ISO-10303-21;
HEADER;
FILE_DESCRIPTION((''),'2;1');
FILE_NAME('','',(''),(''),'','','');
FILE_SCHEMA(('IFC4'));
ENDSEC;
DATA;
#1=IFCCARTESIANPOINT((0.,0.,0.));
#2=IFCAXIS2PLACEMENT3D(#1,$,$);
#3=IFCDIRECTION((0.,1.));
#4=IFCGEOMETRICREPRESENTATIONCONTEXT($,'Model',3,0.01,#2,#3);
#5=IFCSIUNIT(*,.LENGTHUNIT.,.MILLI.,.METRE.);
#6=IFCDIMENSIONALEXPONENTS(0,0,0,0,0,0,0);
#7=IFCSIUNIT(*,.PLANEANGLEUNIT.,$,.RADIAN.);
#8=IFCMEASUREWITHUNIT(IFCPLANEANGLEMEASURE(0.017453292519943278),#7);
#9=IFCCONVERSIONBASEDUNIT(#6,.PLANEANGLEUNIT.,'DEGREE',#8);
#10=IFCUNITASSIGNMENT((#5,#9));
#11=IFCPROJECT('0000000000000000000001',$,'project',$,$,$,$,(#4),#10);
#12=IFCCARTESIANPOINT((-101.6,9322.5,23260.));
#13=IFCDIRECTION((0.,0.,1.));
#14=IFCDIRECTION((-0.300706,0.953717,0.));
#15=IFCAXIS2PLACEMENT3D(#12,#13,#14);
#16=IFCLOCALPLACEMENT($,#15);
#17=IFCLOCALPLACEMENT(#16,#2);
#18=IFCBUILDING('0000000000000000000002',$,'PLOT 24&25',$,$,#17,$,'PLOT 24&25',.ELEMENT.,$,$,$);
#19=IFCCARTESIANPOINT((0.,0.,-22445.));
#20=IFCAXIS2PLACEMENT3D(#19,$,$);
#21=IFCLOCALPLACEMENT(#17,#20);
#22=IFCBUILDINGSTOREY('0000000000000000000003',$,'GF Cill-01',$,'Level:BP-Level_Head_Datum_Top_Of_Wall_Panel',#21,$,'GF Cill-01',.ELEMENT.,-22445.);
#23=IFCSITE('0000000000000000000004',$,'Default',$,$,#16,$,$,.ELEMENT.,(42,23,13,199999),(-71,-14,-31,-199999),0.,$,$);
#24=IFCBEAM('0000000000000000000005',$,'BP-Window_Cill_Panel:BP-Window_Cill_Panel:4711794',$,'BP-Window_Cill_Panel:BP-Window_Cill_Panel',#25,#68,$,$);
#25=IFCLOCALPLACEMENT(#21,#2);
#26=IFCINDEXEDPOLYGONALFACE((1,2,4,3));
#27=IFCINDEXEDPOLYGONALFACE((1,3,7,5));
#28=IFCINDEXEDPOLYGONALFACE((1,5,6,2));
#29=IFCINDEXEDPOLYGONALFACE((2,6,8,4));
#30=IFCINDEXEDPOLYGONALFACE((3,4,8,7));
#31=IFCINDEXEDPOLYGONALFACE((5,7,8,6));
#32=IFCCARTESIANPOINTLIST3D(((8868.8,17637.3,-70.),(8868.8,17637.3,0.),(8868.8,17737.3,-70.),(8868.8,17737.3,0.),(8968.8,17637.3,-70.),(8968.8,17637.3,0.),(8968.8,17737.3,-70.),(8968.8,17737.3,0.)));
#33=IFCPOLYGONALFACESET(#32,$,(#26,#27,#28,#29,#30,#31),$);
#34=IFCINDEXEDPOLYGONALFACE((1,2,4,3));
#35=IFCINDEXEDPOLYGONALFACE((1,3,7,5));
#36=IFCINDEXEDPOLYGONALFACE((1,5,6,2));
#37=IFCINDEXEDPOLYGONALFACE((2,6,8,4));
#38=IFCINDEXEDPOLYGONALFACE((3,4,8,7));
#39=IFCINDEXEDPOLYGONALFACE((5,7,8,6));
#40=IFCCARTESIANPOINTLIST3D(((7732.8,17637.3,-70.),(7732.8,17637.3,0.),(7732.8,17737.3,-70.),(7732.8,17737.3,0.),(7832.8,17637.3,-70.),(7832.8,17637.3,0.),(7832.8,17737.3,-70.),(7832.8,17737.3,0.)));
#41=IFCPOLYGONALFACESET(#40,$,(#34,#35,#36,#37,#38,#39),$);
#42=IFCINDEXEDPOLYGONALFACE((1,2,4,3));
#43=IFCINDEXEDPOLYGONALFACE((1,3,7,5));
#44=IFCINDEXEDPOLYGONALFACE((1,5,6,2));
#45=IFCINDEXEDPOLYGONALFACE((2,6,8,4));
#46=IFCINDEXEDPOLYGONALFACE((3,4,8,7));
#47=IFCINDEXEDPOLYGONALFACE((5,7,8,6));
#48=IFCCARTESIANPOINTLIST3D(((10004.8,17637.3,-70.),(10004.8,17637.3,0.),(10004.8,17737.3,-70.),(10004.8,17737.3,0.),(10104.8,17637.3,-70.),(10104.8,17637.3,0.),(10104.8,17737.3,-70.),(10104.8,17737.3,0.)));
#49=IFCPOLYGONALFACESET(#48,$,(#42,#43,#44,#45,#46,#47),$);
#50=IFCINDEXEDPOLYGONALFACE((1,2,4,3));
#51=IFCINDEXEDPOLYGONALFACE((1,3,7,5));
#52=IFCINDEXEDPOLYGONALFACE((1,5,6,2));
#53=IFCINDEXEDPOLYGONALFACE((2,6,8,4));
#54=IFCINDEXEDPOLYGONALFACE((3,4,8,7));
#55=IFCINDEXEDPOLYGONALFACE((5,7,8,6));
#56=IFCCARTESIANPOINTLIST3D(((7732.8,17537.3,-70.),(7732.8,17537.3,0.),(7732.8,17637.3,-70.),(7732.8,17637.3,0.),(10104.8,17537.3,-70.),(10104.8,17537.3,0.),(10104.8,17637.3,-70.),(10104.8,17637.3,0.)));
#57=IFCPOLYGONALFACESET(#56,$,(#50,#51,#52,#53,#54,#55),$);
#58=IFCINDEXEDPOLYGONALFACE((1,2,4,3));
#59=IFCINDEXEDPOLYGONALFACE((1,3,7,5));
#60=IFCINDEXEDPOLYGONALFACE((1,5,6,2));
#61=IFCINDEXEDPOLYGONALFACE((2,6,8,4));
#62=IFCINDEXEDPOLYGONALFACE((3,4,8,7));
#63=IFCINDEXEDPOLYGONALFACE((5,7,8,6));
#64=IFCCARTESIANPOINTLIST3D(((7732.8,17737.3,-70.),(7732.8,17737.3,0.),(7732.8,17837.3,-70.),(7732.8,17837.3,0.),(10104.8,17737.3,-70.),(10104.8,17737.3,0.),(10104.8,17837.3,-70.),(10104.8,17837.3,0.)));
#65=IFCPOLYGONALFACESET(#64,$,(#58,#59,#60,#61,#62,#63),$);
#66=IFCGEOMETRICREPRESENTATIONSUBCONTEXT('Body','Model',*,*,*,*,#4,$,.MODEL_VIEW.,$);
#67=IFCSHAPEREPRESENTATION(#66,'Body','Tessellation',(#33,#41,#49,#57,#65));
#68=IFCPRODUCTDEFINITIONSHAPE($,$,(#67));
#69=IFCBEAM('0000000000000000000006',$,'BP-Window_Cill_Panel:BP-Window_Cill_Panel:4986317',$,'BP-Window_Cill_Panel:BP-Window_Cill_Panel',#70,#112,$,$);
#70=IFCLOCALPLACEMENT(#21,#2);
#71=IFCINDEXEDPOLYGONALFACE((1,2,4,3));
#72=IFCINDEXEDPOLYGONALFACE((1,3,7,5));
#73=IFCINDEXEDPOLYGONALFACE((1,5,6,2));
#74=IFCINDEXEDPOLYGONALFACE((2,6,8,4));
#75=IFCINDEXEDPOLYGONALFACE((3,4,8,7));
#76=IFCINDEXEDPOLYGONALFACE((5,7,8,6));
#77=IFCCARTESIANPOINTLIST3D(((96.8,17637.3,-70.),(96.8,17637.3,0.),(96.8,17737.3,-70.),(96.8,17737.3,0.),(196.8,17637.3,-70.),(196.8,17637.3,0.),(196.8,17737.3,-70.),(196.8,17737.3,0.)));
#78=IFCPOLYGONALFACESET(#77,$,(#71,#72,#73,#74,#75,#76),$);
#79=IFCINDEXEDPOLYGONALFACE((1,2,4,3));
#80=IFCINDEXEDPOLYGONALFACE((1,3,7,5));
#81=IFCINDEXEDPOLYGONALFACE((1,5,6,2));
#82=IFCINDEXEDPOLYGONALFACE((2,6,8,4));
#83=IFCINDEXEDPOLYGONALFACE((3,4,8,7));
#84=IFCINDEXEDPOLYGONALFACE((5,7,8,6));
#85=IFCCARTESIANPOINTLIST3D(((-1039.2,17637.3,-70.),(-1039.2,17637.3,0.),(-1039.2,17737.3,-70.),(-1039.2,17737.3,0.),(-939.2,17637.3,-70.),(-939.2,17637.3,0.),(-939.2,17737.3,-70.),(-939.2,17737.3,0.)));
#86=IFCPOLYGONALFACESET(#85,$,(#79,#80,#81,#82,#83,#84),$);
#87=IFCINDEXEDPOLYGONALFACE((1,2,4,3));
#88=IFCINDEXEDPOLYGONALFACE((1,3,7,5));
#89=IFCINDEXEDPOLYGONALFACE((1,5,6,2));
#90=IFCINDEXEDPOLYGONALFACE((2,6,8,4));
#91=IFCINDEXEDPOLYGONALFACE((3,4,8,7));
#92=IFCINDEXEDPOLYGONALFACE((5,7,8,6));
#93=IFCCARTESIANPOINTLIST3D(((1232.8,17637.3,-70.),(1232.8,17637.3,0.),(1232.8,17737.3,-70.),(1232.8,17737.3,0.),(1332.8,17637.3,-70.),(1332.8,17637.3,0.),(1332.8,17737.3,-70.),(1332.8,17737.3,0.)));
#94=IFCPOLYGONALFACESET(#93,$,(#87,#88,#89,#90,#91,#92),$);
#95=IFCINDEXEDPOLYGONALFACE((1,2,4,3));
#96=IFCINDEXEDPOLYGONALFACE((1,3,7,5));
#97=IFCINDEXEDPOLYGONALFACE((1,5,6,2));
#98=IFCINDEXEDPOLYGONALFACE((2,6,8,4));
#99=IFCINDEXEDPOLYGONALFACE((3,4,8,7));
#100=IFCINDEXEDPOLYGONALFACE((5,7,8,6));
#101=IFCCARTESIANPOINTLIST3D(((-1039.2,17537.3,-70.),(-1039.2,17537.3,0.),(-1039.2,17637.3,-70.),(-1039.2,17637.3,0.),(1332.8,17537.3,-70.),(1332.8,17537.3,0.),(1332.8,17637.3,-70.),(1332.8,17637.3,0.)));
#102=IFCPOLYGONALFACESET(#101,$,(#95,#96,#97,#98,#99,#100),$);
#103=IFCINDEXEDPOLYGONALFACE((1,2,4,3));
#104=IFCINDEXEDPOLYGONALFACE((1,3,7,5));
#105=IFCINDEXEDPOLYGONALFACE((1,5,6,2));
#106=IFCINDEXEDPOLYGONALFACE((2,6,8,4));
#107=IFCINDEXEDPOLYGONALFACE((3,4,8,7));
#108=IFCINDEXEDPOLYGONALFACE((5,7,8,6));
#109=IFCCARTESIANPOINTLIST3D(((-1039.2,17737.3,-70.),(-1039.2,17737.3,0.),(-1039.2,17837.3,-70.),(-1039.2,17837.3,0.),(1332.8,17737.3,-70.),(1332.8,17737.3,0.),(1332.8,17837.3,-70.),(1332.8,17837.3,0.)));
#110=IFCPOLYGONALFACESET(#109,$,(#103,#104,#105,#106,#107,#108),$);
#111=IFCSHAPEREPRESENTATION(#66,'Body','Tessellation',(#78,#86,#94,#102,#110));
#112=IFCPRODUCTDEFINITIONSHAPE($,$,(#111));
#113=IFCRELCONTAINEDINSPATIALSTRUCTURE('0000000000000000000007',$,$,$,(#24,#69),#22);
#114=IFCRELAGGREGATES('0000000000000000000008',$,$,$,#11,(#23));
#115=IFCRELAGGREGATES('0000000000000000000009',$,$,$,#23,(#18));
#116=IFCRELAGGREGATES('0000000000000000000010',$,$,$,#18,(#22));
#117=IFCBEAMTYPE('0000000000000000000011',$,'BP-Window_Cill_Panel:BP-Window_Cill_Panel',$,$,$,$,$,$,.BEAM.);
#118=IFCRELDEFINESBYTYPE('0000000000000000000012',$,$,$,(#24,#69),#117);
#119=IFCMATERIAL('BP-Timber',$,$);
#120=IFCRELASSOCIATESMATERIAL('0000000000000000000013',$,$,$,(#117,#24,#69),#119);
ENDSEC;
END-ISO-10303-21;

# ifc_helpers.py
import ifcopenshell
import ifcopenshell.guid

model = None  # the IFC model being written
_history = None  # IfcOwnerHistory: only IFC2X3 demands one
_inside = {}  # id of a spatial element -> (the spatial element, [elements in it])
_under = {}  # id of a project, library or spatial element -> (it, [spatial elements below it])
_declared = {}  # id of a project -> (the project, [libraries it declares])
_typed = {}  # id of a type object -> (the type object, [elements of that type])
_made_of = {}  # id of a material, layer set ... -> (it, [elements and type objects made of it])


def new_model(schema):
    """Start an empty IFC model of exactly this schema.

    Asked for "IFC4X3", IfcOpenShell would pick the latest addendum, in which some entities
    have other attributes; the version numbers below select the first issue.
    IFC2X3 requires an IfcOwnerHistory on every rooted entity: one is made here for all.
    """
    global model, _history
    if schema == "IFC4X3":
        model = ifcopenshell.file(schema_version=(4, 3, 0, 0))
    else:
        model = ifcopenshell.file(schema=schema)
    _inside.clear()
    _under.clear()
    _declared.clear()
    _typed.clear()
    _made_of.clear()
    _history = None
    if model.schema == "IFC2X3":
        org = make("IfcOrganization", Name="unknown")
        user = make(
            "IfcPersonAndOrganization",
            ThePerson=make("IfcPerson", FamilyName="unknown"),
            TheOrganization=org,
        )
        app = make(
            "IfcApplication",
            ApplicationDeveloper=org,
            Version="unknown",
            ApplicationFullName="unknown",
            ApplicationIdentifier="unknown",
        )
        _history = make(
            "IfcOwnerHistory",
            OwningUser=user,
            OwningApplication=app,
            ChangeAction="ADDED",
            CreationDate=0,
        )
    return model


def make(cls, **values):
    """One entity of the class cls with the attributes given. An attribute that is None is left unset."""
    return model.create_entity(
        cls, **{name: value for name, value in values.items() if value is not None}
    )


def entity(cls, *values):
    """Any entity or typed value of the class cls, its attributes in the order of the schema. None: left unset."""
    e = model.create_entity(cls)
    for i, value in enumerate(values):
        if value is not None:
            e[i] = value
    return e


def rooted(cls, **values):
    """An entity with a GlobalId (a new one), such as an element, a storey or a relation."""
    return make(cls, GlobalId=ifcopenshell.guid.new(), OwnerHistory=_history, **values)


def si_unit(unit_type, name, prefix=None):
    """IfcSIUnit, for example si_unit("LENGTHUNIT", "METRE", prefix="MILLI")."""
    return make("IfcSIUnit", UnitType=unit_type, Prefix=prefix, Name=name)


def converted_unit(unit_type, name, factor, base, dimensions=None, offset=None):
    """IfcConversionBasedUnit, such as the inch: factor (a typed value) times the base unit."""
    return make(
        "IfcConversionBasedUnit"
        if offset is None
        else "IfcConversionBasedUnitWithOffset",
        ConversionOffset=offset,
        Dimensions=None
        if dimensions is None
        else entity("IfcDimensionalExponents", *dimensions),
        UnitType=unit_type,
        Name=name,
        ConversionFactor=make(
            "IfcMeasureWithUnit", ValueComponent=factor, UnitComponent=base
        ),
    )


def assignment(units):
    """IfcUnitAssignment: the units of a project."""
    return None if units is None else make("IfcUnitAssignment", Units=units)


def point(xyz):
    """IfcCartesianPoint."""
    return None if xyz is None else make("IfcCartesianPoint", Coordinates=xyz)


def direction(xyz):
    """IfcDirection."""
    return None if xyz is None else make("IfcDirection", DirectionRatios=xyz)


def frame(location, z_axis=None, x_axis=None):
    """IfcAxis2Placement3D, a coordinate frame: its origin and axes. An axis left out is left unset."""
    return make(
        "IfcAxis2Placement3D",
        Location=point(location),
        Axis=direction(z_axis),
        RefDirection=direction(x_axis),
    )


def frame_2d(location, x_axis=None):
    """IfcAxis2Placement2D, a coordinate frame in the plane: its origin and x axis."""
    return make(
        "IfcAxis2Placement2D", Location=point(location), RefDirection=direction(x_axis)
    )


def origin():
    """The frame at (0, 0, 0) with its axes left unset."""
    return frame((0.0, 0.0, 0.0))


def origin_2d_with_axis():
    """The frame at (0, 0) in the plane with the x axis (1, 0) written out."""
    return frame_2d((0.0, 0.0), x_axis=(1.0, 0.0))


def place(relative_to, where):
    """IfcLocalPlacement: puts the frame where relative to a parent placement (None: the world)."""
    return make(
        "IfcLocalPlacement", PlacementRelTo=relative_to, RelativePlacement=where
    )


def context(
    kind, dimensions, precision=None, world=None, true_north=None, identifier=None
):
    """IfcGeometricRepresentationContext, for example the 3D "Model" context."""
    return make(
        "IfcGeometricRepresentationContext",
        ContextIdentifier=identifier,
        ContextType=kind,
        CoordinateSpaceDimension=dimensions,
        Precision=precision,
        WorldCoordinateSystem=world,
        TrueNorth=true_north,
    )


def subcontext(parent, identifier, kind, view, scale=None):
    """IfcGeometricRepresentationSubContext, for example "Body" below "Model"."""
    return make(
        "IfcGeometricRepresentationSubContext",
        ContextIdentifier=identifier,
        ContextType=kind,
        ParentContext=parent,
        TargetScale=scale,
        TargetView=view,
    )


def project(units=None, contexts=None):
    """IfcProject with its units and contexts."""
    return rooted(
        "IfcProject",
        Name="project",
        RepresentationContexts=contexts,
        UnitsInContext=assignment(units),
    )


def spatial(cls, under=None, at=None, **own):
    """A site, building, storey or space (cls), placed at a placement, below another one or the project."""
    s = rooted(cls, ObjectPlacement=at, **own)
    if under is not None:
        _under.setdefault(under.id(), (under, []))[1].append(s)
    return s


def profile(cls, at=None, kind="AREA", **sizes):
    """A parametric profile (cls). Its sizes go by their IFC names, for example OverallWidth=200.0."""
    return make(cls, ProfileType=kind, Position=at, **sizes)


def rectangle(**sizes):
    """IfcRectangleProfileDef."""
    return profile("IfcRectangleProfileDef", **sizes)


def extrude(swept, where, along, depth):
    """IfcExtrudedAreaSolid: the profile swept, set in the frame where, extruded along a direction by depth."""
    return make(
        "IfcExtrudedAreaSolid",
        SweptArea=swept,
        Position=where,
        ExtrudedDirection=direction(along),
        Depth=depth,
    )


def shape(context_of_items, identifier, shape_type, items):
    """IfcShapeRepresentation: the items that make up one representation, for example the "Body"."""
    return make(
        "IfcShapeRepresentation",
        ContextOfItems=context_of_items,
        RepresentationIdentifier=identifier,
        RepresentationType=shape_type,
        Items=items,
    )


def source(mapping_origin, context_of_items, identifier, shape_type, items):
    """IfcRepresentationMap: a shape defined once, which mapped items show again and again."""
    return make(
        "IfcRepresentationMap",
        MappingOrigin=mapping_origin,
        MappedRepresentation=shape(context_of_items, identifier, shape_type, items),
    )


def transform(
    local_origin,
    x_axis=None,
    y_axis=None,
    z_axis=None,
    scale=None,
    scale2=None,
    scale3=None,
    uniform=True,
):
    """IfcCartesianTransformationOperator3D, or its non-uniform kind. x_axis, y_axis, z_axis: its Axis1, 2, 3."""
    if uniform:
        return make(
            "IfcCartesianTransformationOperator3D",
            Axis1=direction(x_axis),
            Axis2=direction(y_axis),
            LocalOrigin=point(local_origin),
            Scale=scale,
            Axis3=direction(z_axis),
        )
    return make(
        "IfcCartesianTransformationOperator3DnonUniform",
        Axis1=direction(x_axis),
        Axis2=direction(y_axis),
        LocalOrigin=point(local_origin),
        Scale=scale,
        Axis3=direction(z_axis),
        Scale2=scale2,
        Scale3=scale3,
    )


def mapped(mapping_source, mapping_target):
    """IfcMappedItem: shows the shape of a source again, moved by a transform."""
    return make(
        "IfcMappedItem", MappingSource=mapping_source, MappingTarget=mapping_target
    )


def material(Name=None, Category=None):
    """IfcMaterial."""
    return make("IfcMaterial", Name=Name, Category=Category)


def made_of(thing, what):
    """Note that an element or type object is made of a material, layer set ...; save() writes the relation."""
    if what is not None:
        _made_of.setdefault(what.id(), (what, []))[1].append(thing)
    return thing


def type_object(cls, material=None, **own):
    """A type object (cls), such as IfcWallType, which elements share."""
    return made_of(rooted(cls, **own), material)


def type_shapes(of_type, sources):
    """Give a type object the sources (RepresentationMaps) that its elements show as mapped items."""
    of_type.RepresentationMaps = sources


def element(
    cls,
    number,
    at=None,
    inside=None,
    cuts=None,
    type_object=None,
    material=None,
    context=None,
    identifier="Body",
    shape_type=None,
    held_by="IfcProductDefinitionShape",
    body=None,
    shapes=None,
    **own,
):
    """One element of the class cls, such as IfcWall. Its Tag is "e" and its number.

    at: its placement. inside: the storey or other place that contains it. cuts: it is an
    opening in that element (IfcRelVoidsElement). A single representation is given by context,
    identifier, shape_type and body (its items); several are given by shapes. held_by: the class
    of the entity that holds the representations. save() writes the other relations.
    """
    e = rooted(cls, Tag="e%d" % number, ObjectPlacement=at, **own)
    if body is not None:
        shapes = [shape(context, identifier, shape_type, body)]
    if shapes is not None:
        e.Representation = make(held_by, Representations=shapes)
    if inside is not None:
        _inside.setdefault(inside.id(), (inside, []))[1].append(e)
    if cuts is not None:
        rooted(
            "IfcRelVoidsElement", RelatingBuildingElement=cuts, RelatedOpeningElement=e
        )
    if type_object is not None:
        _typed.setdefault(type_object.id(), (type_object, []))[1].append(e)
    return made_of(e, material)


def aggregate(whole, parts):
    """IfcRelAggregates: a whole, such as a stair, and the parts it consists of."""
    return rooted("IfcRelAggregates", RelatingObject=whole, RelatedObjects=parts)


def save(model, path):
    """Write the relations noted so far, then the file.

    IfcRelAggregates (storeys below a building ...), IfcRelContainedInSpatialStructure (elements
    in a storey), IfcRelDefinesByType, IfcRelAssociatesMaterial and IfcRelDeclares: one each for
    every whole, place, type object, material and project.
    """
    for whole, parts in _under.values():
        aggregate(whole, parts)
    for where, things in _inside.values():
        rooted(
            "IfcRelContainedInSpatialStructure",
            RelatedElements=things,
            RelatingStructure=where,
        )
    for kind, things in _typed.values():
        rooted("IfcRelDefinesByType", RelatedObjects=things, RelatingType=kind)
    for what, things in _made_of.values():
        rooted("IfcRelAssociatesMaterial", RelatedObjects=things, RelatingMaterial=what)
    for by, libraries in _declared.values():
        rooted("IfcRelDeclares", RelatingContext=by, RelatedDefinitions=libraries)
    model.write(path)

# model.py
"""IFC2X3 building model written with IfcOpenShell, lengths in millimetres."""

from ifc_helpers import new_model, entity, si_unit, converted_unit, direction, frame, frame_2d, origin, origin_2d_with_axis, place, context, subcontext, project, spatial, rectangle, extrude, source, transform, mapped, material, type_object, type_shapes, element, save


model = new_model("IFC2X3")

# Units and contexts
model_context = context("Model", 3, precision=0.01, world=origin(), true_north=direction((0.0, 1.0)))
body_context = subcontext(model_context, "Body", "Model", "MODEL_VIEW")
ifc_project = project(units=[si_unit("LENGTHUNIT", "METRE", prefix="MILLI"), converted_unit("PLANEANGLEUNIT", "DEGREE", entity("IfcPlaneAngleMeasure", 0.017453292519943278), si_unit("PLANEANGLEUNIT", "RADIAN"), dimensions=[0, 0, 0, 0, 0, 0, 0])], contexts=[model_context])

# Site, building, storey
site_placement = place(None, frame((-101.6, 9322.5, 23260.0), z_axis=(0.0, 0.0, 1.0), x_axis=(-0.300706, 0.953717, 0.0)))
site = spatial("IfcSite", under=ifc_project, at=site_placement, Name="Default", CompositionType="ELEMENT", RefLatitude=(42, 23, 13, 199999), RefLongitude=(-71, -14, -31, -199999), RefElevation=0.0)
building_placement = place(site_placement, origin())
building = spatial("IfcBuilding", under=site, at=building_placement, Name="PLOT 24&25", LongName="PLOT 24&25", CompositionType="ELEMENT")
storey_placement = place(building_placement, frame((0.0, 0.0, -22445.0)))
storey = spatial("IfcBuildingStorey", under=building, at=storey_placement, Name="GF Cill-01", ObjectType="Level:BP-Level_Head_Datum_Top_Of_Wall_Panel", LongName="GF Cill-01", CompositionType="ELEMENT", Elevation=-22445.0)

# Beams
ifc_material_1 = material(Name="BP-Timber")
beam_type = type_object("IfcBeamType", Name="BP-Window_Cill_Panel:BP-Window_Cill_Panel", PredefinedType="BEAM", material=ifc_material_1)
shared_shape_1 = source(origin(), body_context, "Body", "SweptSolid", [
    extrude(rectangle(XDim=70.0, YDim=100.0, at=frame_2d((0.0, 0.0), x_axis=(1.0, 0.0))), frame((-50.0, 0.0, -35.0), z_axis=(1.0, 0.0, 0.0), x_axis=(0.0, 0.0, -1.0)), (0.0, 0.0, 1.0), 100.0),
    extrude(rectangle(XDim=70.0, YDim=100.0, at=frame_2d((0.0, 0.0), x_axis=(1.0, 0.0))), frame((1086.0, 0.0, -35.0), z_axis=(1.0, 0.0, 0.0), x_axis=(0.0, 0.0, -1.0)), (0.0, 0.0, 1.0), 100.0),
    extrude(rectangle(XDim=70.0, YDim=100.0, at=frame_2d((0.0, 0.0), x_axis=(1.0, 0.0))), frame((-1186.0, 0.0, -35.0), z_axis=(1.0, 0.0, 0.0), x_axis=(0.0, 0.0, -1.0)), (0.0, 0.0, 1.0), 100.0),
    extrude(rectangle(XDim=70.0, YDim=100.0, at=frame_2d((0.0, 0.0), x_axis=(1.0, 0.0))), frame((-1186.0, 100.0, -35.0), z_axis=(1.0, 0.0, 0.0), x_axis=(0.0, 0.0, -1.0)), (0.0, 0.0, 1.0), 2372.0),
    extrude(rectangle(XDim=70.0, YDim=100.0, at=origin_2d_with_axis()), frame((-1186.0, -100.0, -35.0), z_axis=(1.0, 0.0, 0.0), x_axis=(0.0, 0.0, -1.0)), (0.0, 0.0, 1.0), 2372.0),
])
type_shapes(beam_type, [shared_shape_1])
for number, where, z_axis, x_axis, name in (
    (1, (8918.8, 17687.3, 0.0), (0.0, 0.0, 1.0), (-1.0, 0.0, 0.0), "BP-Window_Cill_Panel:BP-Window_Cill_Panel:4711794"),
    (2, (146.8, 17687.3, 0.0), (0.0, 0.0, 1.0), (-1.0, 0.0, 0.0), "BP-Window_Cill_Panel:BP-Window_Cill_Panel:4986317"),
):
    element("IfcBeam", number, at=place(storey_placement, frame(where, z_axis=z_axis, x_axis=x_axis)), inside=storey, type_object=beam_type, material=ifc_material_1, Name=name, ObjectType="BP-Window_Cill_Panel:BP-Window_Cill_Panel", context=body_context, shape_type="MappedRepresentation", body=[
        mapped(shared_shape_1, transform((0.0, 0.0, 0.0), scale=1.0)),
    ])

save(model, "model.ifc")
